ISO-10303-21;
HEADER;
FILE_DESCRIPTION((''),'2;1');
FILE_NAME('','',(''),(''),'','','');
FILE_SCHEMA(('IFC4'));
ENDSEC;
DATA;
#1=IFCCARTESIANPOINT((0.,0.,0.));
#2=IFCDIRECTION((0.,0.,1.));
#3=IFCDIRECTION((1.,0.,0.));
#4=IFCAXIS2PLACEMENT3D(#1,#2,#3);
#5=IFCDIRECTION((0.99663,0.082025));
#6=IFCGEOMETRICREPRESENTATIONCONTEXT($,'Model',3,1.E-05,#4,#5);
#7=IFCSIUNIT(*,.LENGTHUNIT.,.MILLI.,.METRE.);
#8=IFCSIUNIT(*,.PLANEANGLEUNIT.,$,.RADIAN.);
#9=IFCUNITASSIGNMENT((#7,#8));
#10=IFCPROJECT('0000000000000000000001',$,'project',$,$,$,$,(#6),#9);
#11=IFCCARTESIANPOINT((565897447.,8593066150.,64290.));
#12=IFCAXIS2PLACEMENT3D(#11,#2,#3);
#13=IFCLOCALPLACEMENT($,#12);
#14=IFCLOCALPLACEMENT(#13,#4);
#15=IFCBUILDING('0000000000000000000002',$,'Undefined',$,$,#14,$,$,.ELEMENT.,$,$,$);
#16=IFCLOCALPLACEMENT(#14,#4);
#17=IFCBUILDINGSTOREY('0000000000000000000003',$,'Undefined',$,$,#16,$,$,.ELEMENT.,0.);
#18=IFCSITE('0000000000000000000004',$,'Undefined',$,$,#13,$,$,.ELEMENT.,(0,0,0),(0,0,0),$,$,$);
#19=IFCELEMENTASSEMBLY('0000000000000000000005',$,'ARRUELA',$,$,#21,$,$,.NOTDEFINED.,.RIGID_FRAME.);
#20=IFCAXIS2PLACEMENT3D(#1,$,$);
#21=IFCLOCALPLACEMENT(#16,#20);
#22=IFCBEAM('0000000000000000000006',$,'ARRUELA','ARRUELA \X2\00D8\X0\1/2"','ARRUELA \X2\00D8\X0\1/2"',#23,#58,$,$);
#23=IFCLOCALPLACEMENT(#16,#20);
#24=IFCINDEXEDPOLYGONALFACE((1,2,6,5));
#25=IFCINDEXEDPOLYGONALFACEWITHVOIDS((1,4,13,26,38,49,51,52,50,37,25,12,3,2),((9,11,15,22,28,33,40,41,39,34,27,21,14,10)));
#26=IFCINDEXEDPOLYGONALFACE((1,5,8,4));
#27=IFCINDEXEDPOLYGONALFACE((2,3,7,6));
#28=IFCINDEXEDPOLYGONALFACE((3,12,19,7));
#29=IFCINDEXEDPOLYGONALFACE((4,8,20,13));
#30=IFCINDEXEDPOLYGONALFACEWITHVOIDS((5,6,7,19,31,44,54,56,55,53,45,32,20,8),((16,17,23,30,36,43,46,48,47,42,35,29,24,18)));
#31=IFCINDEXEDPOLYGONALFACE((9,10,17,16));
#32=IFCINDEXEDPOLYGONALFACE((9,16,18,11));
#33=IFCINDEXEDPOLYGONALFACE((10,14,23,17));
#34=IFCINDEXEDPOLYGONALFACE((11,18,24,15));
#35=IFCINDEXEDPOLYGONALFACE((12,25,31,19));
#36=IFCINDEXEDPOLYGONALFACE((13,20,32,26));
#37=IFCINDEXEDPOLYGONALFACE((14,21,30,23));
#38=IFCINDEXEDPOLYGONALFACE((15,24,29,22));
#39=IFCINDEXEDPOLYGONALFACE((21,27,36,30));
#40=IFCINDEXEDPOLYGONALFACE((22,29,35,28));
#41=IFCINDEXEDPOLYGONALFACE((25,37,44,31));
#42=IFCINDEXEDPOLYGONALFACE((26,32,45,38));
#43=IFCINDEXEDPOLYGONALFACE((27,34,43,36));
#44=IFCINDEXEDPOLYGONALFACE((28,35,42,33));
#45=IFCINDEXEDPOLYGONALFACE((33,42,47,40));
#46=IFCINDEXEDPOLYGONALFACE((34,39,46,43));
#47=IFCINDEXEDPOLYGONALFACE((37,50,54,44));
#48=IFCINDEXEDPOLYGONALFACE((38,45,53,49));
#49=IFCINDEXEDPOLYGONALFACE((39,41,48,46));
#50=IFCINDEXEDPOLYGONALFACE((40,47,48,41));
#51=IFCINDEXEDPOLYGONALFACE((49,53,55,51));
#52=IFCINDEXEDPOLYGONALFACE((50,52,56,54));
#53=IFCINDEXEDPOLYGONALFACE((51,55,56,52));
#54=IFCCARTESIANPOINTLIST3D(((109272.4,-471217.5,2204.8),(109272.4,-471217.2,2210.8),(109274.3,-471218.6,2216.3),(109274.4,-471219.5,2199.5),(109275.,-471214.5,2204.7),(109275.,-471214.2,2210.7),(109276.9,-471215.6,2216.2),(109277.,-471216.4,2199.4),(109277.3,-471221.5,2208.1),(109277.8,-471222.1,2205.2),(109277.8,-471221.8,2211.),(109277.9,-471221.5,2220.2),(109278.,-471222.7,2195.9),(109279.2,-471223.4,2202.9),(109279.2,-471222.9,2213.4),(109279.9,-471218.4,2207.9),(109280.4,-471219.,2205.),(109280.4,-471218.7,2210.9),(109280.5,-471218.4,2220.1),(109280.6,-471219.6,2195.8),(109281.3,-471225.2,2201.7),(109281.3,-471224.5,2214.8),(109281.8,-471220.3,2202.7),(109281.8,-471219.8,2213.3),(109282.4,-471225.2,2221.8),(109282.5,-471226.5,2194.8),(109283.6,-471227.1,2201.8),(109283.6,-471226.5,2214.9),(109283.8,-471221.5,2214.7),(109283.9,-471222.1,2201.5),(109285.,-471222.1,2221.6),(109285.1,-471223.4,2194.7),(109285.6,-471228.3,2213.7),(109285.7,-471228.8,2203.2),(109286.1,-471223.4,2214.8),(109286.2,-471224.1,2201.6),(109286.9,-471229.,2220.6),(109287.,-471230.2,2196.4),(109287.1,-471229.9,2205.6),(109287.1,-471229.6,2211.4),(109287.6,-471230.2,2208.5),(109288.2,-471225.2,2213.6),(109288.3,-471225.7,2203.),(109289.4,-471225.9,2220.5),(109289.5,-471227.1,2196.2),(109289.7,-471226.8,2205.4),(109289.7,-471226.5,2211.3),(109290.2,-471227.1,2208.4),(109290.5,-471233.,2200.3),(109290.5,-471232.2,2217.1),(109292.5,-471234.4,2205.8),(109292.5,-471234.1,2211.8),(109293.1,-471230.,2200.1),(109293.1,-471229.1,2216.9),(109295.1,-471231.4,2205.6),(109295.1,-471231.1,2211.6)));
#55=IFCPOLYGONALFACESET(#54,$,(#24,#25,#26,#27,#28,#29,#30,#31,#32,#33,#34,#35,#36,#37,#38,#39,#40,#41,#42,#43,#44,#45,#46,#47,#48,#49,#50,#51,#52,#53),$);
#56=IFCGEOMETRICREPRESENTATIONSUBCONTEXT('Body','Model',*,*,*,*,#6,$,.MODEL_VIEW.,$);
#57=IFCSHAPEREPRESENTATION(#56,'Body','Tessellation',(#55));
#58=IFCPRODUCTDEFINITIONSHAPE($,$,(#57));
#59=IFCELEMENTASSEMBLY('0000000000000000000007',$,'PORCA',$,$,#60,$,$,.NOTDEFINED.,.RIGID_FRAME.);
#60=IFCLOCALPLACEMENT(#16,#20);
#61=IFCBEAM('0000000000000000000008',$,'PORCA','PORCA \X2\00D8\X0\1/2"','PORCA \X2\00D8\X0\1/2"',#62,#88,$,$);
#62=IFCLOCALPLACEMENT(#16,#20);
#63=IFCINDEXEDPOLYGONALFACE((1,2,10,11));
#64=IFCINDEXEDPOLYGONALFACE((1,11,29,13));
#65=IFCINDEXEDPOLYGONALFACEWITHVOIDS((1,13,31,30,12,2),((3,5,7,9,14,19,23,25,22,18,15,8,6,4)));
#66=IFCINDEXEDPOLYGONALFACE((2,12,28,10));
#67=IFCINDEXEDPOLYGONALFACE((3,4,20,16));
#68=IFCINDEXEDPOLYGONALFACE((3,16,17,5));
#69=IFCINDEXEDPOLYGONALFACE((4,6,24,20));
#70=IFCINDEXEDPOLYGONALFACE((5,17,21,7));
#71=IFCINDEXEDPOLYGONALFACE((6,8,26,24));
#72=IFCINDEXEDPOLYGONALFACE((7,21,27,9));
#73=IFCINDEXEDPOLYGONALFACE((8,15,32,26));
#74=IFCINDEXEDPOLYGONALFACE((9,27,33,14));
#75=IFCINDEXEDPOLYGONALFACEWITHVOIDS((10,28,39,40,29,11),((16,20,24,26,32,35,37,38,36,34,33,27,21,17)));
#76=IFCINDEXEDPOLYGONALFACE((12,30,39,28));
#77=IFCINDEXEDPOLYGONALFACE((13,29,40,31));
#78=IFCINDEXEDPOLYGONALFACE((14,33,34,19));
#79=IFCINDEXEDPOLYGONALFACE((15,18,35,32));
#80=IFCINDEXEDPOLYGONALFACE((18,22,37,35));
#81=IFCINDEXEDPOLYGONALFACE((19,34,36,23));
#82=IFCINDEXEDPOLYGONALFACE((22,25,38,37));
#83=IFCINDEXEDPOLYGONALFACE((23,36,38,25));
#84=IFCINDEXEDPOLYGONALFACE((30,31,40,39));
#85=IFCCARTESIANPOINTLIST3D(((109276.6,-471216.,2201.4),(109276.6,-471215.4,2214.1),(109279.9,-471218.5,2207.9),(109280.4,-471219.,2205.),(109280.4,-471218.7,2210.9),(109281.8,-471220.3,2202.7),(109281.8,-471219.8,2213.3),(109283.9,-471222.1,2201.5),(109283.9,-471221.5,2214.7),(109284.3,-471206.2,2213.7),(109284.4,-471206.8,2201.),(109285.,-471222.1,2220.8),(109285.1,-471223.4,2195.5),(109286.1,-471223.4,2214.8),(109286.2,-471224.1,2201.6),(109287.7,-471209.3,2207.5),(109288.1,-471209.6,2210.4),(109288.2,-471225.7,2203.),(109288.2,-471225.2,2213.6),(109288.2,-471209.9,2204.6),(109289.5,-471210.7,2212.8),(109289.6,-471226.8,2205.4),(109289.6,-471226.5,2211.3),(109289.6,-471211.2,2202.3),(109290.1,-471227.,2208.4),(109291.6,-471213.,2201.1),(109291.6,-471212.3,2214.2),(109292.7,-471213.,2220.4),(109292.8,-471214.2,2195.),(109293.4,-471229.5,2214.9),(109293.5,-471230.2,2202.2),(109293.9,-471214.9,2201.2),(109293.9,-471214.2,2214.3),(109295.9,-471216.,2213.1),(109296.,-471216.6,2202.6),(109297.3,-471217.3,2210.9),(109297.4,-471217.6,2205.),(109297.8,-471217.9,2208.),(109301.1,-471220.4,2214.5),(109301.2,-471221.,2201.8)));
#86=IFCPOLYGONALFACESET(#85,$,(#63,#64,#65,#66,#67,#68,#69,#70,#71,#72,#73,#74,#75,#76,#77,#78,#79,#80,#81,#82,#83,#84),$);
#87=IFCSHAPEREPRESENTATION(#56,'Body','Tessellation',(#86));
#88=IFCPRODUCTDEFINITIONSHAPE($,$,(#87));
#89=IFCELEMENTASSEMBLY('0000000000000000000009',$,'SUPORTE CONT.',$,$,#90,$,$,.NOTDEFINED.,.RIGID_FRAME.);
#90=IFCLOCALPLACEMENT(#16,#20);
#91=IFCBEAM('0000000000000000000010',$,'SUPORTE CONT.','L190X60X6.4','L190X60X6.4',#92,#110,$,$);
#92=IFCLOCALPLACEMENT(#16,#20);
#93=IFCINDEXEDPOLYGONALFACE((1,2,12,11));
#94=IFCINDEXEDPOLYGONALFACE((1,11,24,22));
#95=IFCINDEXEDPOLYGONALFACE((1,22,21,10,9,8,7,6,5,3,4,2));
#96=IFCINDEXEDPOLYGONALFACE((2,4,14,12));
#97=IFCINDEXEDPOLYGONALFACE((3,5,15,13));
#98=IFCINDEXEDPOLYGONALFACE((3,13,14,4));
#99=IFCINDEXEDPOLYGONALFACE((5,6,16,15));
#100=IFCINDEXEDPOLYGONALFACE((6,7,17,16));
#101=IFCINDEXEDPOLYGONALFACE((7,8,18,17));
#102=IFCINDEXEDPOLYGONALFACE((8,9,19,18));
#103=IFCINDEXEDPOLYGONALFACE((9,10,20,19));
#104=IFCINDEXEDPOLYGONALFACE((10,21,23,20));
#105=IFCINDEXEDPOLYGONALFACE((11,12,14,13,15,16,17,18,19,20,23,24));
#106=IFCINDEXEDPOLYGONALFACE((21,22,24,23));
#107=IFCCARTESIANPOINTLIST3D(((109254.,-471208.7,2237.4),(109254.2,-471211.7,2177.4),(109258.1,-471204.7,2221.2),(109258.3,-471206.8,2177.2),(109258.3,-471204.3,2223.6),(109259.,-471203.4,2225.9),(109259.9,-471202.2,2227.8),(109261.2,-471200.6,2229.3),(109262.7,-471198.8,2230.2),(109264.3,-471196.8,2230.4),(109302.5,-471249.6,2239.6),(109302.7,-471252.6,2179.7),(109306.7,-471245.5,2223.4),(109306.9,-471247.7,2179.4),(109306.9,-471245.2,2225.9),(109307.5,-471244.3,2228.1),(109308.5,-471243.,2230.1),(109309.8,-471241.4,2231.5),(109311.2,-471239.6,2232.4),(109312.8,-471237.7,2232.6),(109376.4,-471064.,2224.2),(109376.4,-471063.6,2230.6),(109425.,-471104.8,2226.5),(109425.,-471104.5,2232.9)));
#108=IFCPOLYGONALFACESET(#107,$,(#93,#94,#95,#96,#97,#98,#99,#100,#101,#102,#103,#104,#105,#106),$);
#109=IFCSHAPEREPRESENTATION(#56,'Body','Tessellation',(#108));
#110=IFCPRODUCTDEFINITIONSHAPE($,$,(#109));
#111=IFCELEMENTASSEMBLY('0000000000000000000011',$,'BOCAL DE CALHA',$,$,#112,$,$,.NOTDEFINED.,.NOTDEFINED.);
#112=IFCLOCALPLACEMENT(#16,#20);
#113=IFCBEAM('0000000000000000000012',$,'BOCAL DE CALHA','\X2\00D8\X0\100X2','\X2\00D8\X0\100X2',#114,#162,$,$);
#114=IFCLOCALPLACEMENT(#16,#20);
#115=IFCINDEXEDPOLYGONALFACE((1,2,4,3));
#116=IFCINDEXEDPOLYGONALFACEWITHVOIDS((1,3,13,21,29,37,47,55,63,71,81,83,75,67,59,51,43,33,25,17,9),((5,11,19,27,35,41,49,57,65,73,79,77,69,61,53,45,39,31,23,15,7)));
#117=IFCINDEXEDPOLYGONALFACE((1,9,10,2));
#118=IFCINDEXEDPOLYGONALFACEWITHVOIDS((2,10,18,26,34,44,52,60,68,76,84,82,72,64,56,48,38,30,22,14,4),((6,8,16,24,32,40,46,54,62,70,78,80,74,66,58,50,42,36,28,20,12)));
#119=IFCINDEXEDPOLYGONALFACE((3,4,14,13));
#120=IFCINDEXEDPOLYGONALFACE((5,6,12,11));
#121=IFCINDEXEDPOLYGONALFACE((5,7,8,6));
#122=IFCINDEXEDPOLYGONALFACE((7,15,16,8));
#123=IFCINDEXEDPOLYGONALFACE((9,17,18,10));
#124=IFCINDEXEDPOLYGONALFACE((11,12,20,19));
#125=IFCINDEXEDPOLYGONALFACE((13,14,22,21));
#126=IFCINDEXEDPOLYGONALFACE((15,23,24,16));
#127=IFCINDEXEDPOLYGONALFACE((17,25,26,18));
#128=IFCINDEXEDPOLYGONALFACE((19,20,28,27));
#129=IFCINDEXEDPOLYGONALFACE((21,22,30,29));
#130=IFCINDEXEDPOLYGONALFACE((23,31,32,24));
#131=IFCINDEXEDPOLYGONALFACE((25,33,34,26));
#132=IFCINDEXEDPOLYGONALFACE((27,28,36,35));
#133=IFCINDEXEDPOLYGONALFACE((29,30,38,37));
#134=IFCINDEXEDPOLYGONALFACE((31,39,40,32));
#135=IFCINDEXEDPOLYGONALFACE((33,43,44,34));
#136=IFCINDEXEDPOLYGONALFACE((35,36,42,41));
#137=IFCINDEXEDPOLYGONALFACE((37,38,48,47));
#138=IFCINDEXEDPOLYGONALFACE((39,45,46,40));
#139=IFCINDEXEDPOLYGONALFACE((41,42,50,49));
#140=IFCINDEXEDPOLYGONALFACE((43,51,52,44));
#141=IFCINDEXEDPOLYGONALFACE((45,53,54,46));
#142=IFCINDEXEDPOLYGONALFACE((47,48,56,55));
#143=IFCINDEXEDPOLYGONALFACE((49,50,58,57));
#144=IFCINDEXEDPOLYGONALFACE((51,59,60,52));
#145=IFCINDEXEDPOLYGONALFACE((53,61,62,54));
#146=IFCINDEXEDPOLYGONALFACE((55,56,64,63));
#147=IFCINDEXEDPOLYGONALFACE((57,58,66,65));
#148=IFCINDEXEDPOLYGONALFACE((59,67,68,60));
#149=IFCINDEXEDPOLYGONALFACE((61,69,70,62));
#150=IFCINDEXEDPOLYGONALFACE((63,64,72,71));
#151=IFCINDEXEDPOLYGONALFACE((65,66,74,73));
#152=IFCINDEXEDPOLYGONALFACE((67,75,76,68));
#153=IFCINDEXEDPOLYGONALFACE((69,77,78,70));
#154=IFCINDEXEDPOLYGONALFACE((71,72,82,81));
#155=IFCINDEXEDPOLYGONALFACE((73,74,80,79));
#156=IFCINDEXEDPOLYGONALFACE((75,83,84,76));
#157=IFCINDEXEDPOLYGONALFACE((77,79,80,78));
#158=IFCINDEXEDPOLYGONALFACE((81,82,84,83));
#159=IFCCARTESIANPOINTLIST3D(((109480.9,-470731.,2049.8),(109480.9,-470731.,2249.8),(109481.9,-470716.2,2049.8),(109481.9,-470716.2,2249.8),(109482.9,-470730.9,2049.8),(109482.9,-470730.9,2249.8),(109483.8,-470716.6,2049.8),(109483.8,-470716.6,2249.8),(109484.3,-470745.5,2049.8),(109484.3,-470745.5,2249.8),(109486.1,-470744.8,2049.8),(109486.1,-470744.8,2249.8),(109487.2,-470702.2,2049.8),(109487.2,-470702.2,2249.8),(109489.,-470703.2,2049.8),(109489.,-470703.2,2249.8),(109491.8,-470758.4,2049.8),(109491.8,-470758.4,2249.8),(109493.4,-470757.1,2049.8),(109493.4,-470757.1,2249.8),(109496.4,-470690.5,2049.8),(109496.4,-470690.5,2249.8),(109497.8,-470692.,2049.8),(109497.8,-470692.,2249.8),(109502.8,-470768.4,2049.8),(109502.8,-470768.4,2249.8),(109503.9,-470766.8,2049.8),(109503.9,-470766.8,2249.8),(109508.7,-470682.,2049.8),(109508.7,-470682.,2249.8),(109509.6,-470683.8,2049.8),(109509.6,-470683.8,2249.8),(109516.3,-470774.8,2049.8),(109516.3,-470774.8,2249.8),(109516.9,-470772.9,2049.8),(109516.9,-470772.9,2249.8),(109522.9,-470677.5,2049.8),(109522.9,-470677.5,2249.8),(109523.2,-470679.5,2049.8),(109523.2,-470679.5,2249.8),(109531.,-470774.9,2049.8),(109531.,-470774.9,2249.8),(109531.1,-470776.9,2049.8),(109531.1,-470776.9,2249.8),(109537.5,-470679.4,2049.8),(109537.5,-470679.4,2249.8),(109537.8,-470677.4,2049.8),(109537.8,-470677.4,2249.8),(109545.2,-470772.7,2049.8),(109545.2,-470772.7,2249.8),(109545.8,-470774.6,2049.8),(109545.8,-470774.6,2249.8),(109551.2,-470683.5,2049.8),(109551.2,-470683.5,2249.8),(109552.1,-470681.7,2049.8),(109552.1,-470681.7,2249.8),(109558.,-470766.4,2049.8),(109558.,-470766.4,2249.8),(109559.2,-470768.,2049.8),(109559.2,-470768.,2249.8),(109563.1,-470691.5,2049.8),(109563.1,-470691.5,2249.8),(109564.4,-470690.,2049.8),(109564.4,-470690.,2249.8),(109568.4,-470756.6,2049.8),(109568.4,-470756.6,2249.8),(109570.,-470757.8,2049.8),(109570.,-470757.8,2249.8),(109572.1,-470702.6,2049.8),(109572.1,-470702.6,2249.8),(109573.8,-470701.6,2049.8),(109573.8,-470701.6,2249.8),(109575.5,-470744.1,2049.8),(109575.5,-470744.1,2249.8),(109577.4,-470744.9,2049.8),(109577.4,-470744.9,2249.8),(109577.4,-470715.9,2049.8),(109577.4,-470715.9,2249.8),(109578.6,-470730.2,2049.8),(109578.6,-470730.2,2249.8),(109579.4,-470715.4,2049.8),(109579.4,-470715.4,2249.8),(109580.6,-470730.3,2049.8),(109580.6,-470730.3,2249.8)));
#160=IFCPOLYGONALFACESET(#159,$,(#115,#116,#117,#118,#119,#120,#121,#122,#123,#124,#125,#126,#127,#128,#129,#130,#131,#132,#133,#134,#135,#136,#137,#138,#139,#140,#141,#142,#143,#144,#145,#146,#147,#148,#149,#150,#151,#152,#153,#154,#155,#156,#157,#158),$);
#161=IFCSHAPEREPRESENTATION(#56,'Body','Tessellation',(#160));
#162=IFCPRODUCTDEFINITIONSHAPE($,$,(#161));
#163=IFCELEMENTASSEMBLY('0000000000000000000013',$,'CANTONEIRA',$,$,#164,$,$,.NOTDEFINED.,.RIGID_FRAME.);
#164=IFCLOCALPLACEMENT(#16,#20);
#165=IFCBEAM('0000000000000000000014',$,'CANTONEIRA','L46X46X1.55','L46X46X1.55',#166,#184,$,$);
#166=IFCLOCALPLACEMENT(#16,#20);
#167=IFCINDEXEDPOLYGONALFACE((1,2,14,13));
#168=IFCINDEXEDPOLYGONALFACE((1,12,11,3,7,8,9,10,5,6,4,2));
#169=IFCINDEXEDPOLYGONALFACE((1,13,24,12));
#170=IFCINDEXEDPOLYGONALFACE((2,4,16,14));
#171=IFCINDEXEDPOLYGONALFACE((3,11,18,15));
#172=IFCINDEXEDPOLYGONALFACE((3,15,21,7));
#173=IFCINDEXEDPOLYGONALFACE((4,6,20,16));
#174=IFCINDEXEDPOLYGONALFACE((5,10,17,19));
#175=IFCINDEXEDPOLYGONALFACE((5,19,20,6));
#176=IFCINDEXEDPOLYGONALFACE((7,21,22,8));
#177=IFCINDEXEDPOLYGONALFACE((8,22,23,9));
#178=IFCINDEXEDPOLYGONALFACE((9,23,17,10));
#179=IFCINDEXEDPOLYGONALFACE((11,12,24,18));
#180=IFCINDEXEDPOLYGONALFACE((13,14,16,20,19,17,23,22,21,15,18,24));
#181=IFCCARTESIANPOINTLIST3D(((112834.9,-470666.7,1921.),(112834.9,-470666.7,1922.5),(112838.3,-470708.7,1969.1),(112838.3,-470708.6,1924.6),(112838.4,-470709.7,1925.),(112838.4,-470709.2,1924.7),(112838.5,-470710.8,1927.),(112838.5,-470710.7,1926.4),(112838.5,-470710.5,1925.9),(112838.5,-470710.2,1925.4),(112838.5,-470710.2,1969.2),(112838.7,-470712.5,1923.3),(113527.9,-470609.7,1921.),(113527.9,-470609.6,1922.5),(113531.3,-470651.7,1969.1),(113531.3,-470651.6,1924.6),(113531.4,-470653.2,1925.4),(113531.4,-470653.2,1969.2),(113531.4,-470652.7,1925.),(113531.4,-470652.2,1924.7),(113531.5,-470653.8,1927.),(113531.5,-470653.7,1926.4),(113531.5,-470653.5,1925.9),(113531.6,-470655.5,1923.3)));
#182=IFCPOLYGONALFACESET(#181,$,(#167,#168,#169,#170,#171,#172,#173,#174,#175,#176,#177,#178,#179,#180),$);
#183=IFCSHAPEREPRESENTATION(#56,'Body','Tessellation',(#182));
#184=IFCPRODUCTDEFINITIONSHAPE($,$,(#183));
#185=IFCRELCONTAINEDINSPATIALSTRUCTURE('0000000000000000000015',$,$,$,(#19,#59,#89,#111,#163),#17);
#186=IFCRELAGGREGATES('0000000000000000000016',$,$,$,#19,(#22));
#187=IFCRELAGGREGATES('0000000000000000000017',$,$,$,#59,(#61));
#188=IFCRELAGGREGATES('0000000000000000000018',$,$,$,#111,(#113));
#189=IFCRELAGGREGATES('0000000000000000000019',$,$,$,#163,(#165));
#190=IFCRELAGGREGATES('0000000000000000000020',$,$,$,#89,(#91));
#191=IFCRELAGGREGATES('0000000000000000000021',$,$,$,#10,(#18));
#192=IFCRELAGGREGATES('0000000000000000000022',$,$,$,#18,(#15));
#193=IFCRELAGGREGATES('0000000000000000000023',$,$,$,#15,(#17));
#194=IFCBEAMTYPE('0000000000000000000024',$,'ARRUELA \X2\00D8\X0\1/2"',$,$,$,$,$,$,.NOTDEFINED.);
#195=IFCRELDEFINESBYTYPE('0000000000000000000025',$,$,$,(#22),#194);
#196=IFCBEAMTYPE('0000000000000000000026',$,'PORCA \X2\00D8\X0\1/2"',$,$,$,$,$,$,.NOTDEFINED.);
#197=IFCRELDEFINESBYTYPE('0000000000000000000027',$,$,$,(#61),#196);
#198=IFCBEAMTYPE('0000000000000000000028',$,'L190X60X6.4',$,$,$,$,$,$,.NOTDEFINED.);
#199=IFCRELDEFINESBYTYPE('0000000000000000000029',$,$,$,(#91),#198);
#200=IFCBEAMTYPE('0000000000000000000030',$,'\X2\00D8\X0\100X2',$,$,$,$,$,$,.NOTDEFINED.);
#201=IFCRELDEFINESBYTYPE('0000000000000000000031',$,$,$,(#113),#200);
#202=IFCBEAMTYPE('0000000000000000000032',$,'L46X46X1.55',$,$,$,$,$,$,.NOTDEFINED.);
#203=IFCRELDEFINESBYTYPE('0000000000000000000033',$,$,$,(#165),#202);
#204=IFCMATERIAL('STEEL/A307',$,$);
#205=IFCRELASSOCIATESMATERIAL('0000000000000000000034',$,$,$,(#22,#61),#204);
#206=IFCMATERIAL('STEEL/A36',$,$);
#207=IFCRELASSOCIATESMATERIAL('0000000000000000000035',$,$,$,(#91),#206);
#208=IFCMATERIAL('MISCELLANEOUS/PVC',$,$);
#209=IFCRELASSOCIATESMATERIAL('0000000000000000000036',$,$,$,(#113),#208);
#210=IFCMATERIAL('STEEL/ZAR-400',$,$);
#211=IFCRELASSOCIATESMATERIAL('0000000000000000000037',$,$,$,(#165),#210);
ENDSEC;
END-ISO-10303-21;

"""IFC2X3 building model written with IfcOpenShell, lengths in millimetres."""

from ifc_helpers import new_model, si_unit, direction, frame, frame_2d, origin_with_axes, place, context, subcontext, project, spatial, polyline, hollow_circle, l_section, outline, extrude, material, type_object, element, aggregate, save


model = new_model("IFC2X3")

# Units and contexts
model_context = context("Model", 3, precision=1e-05, world=origin_with_axes(), true_north=direction((0.99663, 0.082025)))
body_context = subcontext(model_context, "Body", "Model", "MODEL_VIEW")
ifc_project = project(units=[si_unit("LENGTHUNIT", "METRE", prefix="MILLI"), si_unit("PLANEANGLEUNIT", "RADIAN")], contexts=[model_context])

# Site, building, storey
site_placement = place(None, frame((565897447.0, 8593066150.0, 64290.0), z_axis=(0.0, 0.0, 1.0), x_axis=(1.0, 0.0, 0.0)))
site = spatial("IfcSite", under=ifc_project, at=site_placement, Name="Undefined", CompositionType="ELEMENT", RefLatitude=(0, 0, 0), RefLongitude=(0, 0, 0))
building_placement = place(site_placement, origin_with_axes())
building = spatial("IfcBuilding", under=site, at=building_placement, Name="Undefined", CompositionType="ELEMENT")
storey_placement = place(building_placement, origin_with_axes())
storey = spatial("IfcBuildingStorey", under=building, at=storey_placement, Name="Undefined", CompositionType="ELEMENT", Elevation=0.0)

# Element assemblies, beams
assembly_1_placement = place(storey_placement, origin_with_axes())
assembly_1 = element("IfcElementAssembly", 1, at=assembly_1_placement, inside=storey, Name="ARRUELA", AssemblyPlace="NOTDEFINED", PredefinedType="RIGID_FRAME")
ifc_material_1 = material(Name="STEEL/A307")
beam_type_1 = type_object("IfcBeamType", Name="ARRUELA Ø1/2\"", PredefinedType="NOTDEFINED")
beam_1_placement = place(assembly_1_placement, frame((109285.0, -471222.8, 2208.1), z_axis=(-0.764529, 0.643627, -0.035208), x_axis=(-0.644577, -0.763719, 0.035414)))
beam_1 = element("IfcBeam", 2, at=beam_1_placement, type_object=beam_type_1, material=ifc_material_1, Name="ARRUELA", Description="ARRUELA Ø1/2\"", ObjectType="ARRUELA Ø1/2\"", context=body_context, shape_type="SweptSolid", body=[
    extrude(outline(polyline([(-8.4, 10.5), (-3.0, 13.2), (3.0, 13.2), (8.4, 10.5), (12.2, 5.9), (13.5, 0.0), (12.2, -5.9), (8.4, -10.5), (3.0, -13.2), (-3.0, -13.2), (-8.4, -10.5), (-12.2, -5.9), (-13.5, 0.0), (-12.2, 5.9), (-8.4, 10.5)]), holes=[polyline([(6.6, 1.5), (5.3, 4.2), (2.9, 6.1), (0.0, 6.7), (-2.9, 6.1), (-5.3, 4.2), (-6.6, 1.5), (-6.6, -1.5), (-5.3, -4.2), (-2.9, -6.1), (0.0, -6.8), (2.9, -6.1), (5.3, -4.2), (6.6, -1.5), (6.6, 1.5)])]), frame((4.0, 0.0, 0.0), z_axis=(-1.0, 0.0, 0.0), x_axis=(0.0, -1.0, 0.0)), (0.0, 0.0, 1.0), 4.0),
])
aggregate(assembly_1, [beam_1])
assembly_2_placement = place(storey_placement, origin_with_axes())
assembly_2 = element("IfcElementAssembly", 3, at=assembly_2_placement, inside=storey, Name="PORCA", AssemblyPlace="NOTDEFINED", PredefinedType="RIGID_FRAME")
beam_type_2 = type_object("IfcBeamType", Name="PORCA Ø1/2\"", PredefinedType="NOTDEFINED")
beam_2_placement = place(assembly_2_placement, frame((109292.8, -471213.6, 2207.7), z_axis=(-0.764529, 0.643627, -0.035208), x_axis=(-0.644577, -0.763719, 0.035414)))
beam_2 = element("IfcBeam", 4, at=beam_2_placement, type_object=beam_type_2, material=ifc_material_1, Name="PORCA", Description="PORCA Ø1/2\"", ObjectType="PORCA Ø1/2\"", context=body_context, shape_type="SweptSolid", body=[
    extrude(outline(polyline([(12.7, 0.0), (6.3, -11.0), (-6.3, -11.0), (-12.7, 0.0), (-6.3, 11.0), (6.3, 11.0), (12.7, 0.0)]), holes=[polyline([(-5.3, -4.2), (-2.9, -6.0), (0.0, -6.7), (2.9, -6.0), (5.3, -4.2), (6.6, -1.5), (6.6, 1.5), (5.3, 4.2), (2.9, 6.0), (0.0, 6.7), (-2.9, 6.0), (-5.3, 4.2), (-6.6, 1.5), (-6.6, -1.5), (-5.3, -4.2)])]), frame((12.0, 0.0, 0.0), z_axis=(-1.0, 0.0, 0.0), x_axis=(0.0, -1.0, 0.0)), (0.0, 0.0, 1.0), 12.0),
])
aggregate(assembly_2, [beam_2])
assembly_3_placement = place(storey_placement, origin_with_axes())
assembly_3 = element("IfcElementAssembly", 5, at=assembly_3_placement, inside=storey, Name="SUPORTE CONT.", AssemblyPlace="NOTDEFINED", PredefinedType="RIGID_FRAME")
ifc_material_2 = material(Name="STEEL/A36")
beam_type_3 = type_object("IfcBeamType", Name="L190X60X6.4", PredefinedType="NOTDEFINED")
beam_3_placement = place(assembly_3_placement, frame((109363.9, -471178.6, 2206.3), z_axis=(0.644577, 0.763719, -0.035414), x_axis=(-0.764529, 0.643627, -0.035208)))
beam_3 = element("IfcBeam", 6, at=beam_3_placement, type_object=beam_type_3, material=ifc_material_2, Name="SUPORTE CONT.", Description="L190X60X6.4", ObjectType="L190X60X6.4", context=body_context, shape_type="SweptSolid", body=[
    extrude(l_section(Depth=190.0, Width=60.0, Thickness=6.4, FilletRadius=9.6, at=frame_2d((0.0, 0.0), x_axis=(1.0, 0.0))), frame((63.5, 0.0, 0.0), z_axis=(-1.0, 0.0, 0.0), x_axis=(0.0, -1.0, 0.0)), (0.0, 0.0, 1.0), 63.5),
])
assembly_4_placement = place(storey_placement, origin_with_axes())
assembly_4 = element("IfcElementAssembly", 7, at=assembly_4_placement, inside=storey, Name="BOCAL DE CALHA", AssemblyPlace="NOTDEFINED", PredefinedType="NOTDEFINED")
ifc_material_3 = material(Name="MISCELLANEOUS/PVC")
beam_type_4 = type_object("IfcBeamType", Name="Ø100X2", PredefinedType="NOTDEFINED")
beam_4_placement = place(assembly_4_placement, frame((109530.7, -470726.9, 2249.8), z_axis=(0.082025, -0.99663, 0.0), x_axis=(0.0, 0.0, -1.0)))
beam_4 = element("IfcBeam", 8, at=beam_4_placement, type_object=beam_type_4, material=ifc_material_3, Name="BOCAL DE CALHA", Description="Ø100X2", ObjectType="Ø100X2", context=body_context, shape_type="SweptSolid", body=[
    extrude(hollow_circle(Radius=50.0, WallThickness=2.0, at=frame_2d((0.0, 0.0), x_axis=(1.0, 0.0))), frame((200.0, 0.0, 0.0), z_axis=(-1.0, 0.0, 0.0), x_axis=(0.0, -1.0, 0.0)), (0.0, 0.0, 1.0), 200.0),
])
aggregate(assembly_4, [beam_4])
assembly_5_placement = place(storey_placement, origin_with_axes())
assembly_5 = element("IfcElementAssembly", 9, at=assembly_5_placement, inside=storey, Name="CANTONEIRA", AssemblyPlace="NOTDEFINED", PredefinedType="RIGID_FRAME")
ifc_material_4 = material(Name="STEEL/ZAR-400")
beam_type_5 = type_object("IfcBeamType", Name="L46X46X1.55", PredefinedType="NOTDEFINED")
beam_5_placement = place(assembly_5_placement, frame((112836.7, -470688.5, 1945.1), z_axis=(-0.081923, 0.995387, -0.049938), x_axis=(0.99663, 0.082025, 0.0)))
beam_5 = element("IfcBeam", 10, at=beam_5_placement, type_object=beam_type_5, material=ifc_material_4, Name="CANTONEIRA", Description="L46X46X1.55", ObjectType="L46X46X1.55", context=body_context, shape_type="SweptSolid", body=[
    extrude(l_section(Depth=46.0, Width=46.0, Thickness=1.6, FilletRadius=2.3, at=frame_2d((0.0, 0.0), x_axis=(1.0, 0.0))), frame((695.3, 0.0, 0.0), z_axis=(-1.0, 0.0, 0.0), x_axis=(0.0, -1.0, 0.0)), (0.0, 0.0, 1.0), 695.3),
])
aggregate(assembly_5, [beam_5])

aggregate(assembly_3, [beam_3])

save(model, "model.ifc")
